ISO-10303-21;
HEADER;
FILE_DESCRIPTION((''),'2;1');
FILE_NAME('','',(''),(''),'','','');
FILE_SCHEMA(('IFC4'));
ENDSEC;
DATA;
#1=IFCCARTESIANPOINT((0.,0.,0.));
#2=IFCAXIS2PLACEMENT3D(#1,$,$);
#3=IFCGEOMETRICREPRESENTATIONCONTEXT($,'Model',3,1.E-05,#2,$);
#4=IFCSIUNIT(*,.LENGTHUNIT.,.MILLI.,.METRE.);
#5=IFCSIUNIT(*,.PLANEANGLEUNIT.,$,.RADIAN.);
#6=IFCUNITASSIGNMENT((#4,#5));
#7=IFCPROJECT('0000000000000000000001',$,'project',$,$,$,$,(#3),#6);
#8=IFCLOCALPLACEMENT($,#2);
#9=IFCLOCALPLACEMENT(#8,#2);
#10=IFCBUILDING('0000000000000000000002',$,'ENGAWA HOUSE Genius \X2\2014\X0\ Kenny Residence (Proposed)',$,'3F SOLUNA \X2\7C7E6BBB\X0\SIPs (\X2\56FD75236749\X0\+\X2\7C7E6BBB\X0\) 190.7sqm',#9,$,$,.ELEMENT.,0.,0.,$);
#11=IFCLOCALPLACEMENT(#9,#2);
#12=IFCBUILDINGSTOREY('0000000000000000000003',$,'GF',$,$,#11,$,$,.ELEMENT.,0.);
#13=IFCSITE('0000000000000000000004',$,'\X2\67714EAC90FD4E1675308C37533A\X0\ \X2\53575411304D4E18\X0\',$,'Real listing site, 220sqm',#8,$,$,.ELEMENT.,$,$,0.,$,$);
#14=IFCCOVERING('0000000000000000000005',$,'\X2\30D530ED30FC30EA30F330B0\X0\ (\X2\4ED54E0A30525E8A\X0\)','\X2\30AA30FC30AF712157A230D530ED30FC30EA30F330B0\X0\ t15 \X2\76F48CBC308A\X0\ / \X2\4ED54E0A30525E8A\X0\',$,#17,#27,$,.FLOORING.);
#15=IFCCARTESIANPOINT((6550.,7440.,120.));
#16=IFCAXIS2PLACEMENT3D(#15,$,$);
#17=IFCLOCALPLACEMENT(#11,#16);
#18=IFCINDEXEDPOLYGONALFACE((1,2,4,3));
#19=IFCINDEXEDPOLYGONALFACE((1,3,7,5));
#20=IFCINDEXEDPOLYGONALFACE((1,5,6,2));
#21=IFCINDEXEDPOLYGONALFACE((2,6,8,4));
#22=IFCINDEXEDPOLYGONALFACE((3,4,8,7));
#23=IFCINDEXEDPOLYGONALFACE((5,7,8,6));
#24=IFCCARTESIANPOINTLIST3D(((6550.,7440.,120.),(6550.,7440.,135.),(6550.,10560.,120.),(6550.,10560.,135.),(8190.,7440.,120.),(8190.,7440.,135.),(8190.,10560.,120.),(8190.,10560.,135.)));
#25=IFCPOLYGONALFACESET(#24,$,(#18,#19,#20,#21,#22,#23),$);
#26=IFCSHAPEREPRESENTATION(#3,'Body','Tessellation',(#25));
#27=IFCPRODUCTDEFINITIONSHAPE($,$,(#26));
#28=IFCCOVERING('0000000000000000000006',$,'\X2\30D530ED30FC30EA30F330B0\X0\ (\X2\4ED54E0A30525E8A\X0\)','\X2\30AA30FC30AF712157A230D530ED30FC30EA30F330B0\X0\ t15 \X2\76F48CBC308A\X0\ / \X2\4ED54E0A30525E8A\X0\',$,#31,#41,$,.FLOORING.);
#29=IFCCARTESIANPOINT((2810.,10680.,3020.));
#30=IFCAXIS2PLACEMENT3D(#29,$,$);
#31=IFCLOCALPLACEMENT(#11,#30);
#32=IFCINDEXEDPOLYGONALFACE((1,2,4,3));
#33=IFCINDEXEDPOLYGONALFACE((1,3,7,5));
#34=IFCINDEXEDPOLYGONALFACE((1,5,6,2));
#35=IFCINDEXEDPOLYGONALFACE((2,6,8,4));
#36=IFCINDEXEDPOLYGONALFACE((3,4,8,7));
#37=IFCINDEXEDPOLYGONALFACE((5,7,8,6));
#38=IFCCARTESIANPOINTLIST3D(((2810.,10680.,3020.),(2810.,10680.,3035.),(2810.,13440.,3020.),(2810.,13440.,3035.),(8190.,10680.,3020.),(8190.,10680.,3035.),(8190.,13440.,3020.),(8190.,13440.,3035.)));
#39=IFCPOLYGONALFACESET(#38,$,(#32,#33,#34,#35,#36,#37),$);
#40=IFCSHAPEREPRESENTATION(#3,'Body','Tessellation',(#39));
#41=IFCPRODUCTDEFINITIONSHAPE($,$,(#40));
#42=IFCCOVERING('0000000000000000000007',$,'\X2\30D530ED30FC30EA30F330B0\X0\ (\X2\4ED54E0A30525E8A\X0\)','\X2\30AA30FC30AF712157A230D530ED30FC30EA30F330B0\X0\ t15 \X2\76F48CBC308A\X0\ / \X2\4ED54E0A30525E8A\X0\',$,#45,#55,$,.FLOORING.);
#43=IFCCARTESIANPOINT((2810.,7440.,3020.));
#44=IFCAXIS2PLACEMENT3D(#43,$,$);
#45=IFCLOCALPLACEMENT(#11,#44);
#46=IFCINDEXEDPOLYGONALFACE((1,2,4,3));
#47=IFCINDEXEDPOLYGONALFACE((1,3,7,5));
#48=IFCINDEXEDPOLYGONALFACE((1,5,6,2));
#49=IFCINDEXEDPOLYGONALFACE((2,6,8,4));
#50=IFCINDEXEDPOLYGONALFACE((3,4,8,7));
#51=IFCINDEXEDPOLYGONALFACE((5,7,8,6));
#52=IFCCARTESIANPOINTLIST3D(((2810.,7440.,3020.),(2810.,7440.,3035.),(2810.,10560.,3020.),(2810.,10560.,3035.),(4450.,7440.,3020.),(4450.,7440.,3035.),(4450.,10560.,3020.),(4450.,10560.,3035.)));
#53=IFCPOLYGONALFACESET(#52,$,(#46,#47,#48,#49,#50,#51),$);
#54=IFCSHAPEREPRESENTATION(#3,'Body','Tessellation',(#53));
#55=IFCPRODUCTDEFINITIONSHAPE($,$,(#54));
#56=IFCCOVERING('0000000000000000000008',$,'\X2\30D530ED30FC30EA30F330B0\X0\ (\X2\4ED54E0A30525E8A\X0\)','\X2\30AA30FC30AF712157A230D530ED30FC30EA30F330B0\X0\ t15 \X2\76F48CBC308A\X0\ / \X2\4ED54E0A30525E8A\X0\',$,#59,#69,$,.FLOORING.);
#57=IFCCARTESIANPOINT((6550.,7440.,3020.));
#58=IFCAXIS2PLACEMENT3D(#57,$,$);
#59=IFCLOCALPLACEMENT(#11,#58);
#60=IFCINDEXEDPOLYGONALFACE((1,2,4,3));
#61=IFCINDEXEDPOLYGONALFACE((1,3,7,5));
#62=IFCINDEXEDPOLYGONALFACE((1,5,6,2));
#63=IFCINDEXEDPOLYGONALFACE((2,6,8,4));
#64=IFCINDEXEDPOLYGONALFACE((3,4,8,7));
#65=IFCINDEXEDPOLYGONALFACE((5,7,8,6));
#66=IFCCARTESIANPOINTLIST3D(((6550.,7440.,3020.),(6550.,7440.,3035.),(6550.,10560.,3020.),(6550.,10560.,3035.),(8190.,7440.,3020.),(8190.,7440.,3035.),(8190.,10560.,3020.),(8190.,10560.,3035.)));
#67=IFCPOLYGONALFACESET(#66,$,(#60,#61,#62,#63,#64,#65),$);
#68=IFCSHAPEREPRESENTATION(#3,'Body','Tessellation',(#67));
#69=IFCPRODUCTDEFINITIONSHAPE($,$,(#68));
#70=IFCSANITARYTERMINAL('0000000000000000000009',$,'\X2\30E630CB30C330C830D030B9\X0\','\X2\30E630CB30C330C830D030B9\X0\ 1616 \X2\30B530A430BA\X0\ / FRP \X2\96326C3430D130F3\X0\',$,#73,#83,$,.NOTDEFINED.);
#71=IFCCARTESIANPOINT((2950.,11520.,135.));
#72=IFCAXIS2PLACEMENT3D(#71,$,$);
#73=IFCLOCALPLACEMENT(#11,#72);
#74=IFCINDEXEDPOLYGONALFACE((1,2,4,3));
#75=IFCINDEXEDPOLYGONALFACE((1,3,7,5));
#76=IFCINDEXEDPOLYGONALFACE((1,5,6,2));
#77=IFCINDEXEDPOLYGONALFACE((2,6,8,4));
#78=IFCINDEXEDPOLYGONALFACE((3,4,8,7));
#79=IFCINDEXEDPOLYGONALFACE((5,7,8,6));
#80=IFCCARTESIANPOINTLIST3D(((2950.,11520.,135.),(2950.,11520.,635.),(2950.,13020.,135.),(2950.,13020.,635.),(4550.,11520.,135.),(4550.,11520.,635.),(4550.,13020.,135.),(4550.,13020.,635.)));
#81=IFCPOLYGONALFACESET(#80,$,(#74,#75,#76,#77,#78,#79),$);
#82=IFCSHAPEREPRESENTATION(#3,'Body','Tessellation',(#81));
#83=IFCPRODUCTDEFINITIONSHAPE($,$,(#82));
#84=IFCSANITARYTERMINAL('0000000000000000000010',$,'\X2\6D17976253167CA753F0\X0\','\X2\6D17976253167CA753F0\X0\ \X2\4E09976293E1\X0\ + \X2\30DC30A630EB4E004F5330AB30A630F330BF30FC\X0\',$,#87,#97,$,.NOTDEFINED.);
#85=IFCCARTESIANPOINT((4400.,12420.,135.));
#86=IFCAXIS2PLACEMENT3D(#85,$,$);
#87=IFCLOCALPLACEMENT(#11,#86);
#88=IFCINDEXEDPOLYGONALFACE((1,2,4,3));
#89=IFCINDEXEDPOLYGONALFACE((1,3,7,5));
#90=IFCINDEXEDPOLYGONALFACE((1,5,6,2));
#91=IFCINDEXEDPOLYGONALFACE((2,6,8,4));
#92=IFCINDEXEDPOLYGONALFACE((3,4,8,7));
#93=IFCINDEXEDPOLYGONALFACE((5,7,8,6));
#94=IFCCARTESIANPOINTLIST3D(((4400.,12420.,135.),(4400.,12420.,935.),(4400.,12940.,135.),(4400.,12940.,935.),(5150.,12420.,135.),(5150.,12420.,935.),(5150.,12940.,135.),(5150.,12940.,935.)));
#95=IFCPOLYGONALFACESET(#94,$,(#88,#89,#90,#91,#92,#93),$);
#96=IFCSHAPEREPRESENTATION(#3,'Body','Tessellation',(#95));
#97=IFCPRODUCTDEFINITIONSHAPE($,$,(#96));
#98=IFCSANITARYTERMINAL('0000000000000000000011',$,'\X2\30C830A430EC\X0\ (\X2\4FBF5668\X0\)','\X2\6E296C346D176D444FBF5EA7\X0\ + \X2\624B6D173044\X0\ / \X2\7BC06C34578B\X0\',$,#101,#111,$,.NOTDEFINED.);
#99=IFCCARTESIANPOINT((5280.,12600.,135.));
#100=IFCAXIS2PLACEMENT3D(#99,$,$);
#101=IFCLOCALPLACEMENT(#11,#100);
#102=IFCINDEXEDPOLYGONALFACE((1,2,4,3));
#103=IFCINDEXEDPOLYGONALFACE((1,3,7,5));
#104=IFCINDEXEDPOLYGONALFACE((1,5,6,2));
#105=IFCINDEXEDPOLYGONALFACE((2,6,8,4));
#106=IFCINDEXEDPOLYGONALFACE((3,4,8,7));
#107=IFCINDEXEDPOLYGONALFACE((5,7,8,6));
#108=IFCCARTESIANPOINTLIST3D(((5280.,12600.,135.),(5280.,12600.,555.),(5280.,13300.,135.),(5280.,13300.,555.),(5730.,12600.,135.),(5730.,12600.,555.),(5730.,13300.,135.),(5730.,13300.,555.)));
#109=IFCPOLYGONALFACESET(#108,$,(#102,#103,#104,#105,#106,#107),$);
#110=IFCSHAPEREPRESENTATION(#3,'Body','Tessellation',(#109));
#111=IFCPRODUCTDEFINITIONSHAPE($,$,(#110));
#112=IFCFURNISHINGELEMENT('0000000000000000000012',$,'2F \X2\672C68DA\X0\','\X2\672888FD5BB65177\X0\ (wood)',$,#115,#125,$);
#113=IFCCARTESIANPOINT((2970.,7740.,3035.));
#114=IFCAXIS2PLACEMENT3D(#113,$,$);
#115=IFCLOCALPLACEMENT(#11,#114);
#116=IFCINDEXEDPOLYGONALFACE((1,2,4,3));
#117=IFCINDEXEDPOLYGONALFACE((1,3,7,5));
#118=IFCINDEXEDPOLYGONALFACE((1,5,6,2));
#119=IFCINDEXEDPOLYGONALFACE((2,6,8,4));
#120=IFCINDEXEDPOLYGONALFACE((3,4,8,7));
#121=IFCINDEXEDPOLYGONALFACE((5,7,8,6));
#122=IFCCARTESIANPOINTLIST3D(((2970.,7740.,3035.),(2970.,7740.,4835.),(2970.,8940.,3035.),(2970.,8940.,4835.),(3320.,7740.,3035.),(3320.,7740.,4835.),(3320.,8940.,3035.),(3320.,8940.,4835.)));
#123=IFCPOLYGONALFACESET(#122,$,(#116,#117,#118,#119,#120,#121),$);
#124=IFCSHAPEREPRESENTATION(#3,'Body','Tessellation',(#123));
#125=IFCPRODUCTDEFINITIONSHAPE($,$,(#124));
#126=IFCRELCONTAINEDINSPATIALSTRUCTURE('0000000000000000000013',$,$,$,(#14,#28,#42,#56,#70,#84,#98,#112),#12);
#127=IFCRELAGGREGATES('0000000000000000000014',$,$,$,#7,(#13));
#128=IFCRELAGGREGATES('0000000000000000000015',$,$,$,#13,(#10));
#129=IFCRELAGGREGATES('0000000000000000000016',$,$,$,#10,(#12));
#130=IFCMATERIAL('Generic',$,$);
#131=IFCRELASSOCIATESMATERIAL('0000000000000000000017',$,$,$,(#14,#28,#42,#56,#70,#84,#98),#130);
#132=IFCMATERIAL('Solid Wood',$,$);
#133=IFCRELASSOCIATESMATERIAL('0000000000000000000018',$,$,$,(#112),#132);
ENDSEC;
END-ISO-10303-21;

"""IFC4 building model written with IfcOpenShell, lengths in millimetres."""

from ifc_helpers import new_model, si_unit, frame, frame_2d, origin, place, context, project, spatial, rectangle, extrude, material, element, save


model = new_model("IFC4")

# Units and contexts
model_context = context("Model", 3, precision=1e-05, world=origin())
ifc_project = project(units=[si_unit("LENGTHUNIT", "METRE", prefix="MILLI"), si_unit("PLANEANGLEUNIT", "RADIAN")], contexts=[model_context])

# Site, building, storey
site_placement = place(None, origin())
site = spatial("IfcSite", under=ifc_project, at=site_placement, Name="東京都世田谷区 南向き丘", ObjectType="Real listing site, 220sqm", CompositionType="ELEMENT", RefElevation=0.0)
building_placement = place(site_placement, origin())
building = spatial("IfcBuilding", under=site, at=building_placement, Name="ENGAWA HOUSE Genius — Kenny Residence (Proposed)", ObjectType="3F SOLUNA 籾殻SIPs (国産杉+籾殻) 190.7sqm", CompositionType="ELEMENT", ElevationOfRefHeight=0.0, ElevationOfTerrain=0.0)
storey_placement = place(building_placement, origin())
storey = spatial("IfcBuildingStorey", under=building, at=storey_placement, Name="GF", CompositionType="ELEMENT", Elevation=0.0)

# Shared definitions
ifc_material_1 = material(Name="Solid Wood")

# Coverings
ifc_material_2 = material(Name="Generic")
covering_1_placement = place(storey_placement, frame((6550.0, 7440.0, 120.0)))
element("IfcCovering", 1, at=covering_1_placement, inside=storey, material=ifc_material_2, Name="フローリング (仕上げ床)", Description="オーク無垢フローリング t15 直貼り / 仕上げ床", PredefinedType="FLOORING", context=model_context, shape_type="SweptSolid", body=[
    extrude(rectangle(XDim=1640.0, YDim=3120.0, at=frame_2d((820.0, 1560.0))), frame((6550.0, 7440.0, 120.0)), (0.0, 0.0, 1.0), 15.0),
])
covering_2_placement = place(storey_placement, frame((2810.0, 10680.0, 3020.0)))
element("IfcCovering", 2, at=covering_2_placement, inside=storey, material=ifc_material_2, Name="フローリング (仕上げ床)", Description="オーク無垢フローリング t15 直貼り / 仕上げ床", PredefinedType="FLOORING", context=model_context, shape_type="SweptSolid", body=[
    extrude(rectangle(XDim=5380.0, YDim=2760.0, at=frame_2d((2690.0, 1380.0))), frame((2810.0, 10680.0, 3020.0)), (0.0, 0.0, 1.0), 15.0),
])
covering_3_placement = place(storey_placement, frame((2810.0, 7440.0, 3020.0)))
element("IfcCovering", 3, at=covering_3_placement, inside=storey, material=ifc_material_2, Name="フローリング (仕上げ床)", Description="オーク無垢フローリング t15 直貼り / 仕上げ床", PredefinedType="FLOORING", context=model_context, shape_type="SweptSolid", body=[
    extrude(rectangle(XDim=1640.0, YDim=3120.0, at=frame_2d((820.0, 1560.0))), frame((2810.0, 7440.0, 3020.0)), (0.0, 0.0, 1.0), 15.0),
])
covering_4_placement = place(storey_placement, frame((6550.0, 7440.0, 3020.0)))
element("IfcCovering", 4, at=covering_4_placement, inside=storey, material=ifc_material_2, Name="フローリング (仕上げ床)", Description="オーク無垢フローリング t15 直貼り / 仕上げ床", PredefinedType="FLOORING", context=model_context, shape_type="SweptSolid", body=[
    extrude(rectangle(XDim=1640.0, YDim=3120.0, at=frame_2d((820.0, 1560.0))), frame((6550.0, 7440.0, 3020.0)), (0.0, 0.0, 1.0), 15.0),
])

# Sanitary terminals
sanitary_terminal_1_placement = place(storey_placement, frame((2950.0, 11520.0, 135.0)))
element("IfcSanitaryTerminal", 5, at=sanitary_terminal_1_placement, inside=storey, material=ifc_material_2, Name="ユニットバス", Description="ユニットバス 1616 サイズ / FRP 防水パン", PredefinedType="NOTDEFINED", context=model_context, shape_type="SweptSolid", body=[
    extrude(rectangle(XDim=1600.0, YDim=1500.0, at=frame_2d((800.0, 750.0))), frame((2950.0, 11520.0, 135.0)), (0.0, 0.0, 1.0), 500.0),
])
sanitary_terminal_2_placement = place(storey_placement, frame((4400.0, 12420.0, 135.0)))
element("IfcSanitaryTerminal", 6, at=sanitary_terminal_2_placement, inside=storey, material=ifc_material_2, Name="洗面化粧台", Description="洗面化粧台 三面鏡 + ボウル一体カウンター", PredefinedType="NOTDEFINED", context=model_context, shape_type="SweptSolid", body=[
    extrude(rectangle(XDim=750.0, YDim=520.0, at=frame_2d((375.0, 260.0))), frame((4400.0, 12420.0, 135.0)), (0.0, 0.0, 1.0), 800.0),
])
sanitary_terminal_3_placement = place(storey_placement, frame((5280.0, 12600.0, 135.0)))
element("IfcSanitaryTerminal", 7, at=sanitary_terminal_3_placement, inside=storey, material=ifc_material_2, Name="トイレ (便器)", Description="温水洗浄便座 + 手洗い / 節水型", PredefinedType="NOTDEFINED", context=model_context, shape_type="SweptSolid", body=[
    extrude(rectangle(XDim=450.0, YDim=700.0, at=frame_2d((225.0, 350.0))), frame((5280.0, 12600.0, 135.0)), (0.0, 0.0, 1.0), 420.0),
])

# Furnishing element
furnishing_placement = place(storey_placement, frame((2970.0, 7740.0, 3035.0)))
element("IfcFurnishingElement", 8, at=furnishing_placement, inside=storey, material=ifc_material_1, Name="2F 本棚", Description="木製家具 (wood)", context=model_context, shape_type="SweptSolid", body=[
    extrude(rectangle(XDim=350.0, YDim=1200.0, at=frame_2d((175.0, 600.0))), frame((2970.0, 7740.0, 3035.0)), (0.0, 0.0, 1.0), 1800.0),
])

save(model, "model.ifc")
